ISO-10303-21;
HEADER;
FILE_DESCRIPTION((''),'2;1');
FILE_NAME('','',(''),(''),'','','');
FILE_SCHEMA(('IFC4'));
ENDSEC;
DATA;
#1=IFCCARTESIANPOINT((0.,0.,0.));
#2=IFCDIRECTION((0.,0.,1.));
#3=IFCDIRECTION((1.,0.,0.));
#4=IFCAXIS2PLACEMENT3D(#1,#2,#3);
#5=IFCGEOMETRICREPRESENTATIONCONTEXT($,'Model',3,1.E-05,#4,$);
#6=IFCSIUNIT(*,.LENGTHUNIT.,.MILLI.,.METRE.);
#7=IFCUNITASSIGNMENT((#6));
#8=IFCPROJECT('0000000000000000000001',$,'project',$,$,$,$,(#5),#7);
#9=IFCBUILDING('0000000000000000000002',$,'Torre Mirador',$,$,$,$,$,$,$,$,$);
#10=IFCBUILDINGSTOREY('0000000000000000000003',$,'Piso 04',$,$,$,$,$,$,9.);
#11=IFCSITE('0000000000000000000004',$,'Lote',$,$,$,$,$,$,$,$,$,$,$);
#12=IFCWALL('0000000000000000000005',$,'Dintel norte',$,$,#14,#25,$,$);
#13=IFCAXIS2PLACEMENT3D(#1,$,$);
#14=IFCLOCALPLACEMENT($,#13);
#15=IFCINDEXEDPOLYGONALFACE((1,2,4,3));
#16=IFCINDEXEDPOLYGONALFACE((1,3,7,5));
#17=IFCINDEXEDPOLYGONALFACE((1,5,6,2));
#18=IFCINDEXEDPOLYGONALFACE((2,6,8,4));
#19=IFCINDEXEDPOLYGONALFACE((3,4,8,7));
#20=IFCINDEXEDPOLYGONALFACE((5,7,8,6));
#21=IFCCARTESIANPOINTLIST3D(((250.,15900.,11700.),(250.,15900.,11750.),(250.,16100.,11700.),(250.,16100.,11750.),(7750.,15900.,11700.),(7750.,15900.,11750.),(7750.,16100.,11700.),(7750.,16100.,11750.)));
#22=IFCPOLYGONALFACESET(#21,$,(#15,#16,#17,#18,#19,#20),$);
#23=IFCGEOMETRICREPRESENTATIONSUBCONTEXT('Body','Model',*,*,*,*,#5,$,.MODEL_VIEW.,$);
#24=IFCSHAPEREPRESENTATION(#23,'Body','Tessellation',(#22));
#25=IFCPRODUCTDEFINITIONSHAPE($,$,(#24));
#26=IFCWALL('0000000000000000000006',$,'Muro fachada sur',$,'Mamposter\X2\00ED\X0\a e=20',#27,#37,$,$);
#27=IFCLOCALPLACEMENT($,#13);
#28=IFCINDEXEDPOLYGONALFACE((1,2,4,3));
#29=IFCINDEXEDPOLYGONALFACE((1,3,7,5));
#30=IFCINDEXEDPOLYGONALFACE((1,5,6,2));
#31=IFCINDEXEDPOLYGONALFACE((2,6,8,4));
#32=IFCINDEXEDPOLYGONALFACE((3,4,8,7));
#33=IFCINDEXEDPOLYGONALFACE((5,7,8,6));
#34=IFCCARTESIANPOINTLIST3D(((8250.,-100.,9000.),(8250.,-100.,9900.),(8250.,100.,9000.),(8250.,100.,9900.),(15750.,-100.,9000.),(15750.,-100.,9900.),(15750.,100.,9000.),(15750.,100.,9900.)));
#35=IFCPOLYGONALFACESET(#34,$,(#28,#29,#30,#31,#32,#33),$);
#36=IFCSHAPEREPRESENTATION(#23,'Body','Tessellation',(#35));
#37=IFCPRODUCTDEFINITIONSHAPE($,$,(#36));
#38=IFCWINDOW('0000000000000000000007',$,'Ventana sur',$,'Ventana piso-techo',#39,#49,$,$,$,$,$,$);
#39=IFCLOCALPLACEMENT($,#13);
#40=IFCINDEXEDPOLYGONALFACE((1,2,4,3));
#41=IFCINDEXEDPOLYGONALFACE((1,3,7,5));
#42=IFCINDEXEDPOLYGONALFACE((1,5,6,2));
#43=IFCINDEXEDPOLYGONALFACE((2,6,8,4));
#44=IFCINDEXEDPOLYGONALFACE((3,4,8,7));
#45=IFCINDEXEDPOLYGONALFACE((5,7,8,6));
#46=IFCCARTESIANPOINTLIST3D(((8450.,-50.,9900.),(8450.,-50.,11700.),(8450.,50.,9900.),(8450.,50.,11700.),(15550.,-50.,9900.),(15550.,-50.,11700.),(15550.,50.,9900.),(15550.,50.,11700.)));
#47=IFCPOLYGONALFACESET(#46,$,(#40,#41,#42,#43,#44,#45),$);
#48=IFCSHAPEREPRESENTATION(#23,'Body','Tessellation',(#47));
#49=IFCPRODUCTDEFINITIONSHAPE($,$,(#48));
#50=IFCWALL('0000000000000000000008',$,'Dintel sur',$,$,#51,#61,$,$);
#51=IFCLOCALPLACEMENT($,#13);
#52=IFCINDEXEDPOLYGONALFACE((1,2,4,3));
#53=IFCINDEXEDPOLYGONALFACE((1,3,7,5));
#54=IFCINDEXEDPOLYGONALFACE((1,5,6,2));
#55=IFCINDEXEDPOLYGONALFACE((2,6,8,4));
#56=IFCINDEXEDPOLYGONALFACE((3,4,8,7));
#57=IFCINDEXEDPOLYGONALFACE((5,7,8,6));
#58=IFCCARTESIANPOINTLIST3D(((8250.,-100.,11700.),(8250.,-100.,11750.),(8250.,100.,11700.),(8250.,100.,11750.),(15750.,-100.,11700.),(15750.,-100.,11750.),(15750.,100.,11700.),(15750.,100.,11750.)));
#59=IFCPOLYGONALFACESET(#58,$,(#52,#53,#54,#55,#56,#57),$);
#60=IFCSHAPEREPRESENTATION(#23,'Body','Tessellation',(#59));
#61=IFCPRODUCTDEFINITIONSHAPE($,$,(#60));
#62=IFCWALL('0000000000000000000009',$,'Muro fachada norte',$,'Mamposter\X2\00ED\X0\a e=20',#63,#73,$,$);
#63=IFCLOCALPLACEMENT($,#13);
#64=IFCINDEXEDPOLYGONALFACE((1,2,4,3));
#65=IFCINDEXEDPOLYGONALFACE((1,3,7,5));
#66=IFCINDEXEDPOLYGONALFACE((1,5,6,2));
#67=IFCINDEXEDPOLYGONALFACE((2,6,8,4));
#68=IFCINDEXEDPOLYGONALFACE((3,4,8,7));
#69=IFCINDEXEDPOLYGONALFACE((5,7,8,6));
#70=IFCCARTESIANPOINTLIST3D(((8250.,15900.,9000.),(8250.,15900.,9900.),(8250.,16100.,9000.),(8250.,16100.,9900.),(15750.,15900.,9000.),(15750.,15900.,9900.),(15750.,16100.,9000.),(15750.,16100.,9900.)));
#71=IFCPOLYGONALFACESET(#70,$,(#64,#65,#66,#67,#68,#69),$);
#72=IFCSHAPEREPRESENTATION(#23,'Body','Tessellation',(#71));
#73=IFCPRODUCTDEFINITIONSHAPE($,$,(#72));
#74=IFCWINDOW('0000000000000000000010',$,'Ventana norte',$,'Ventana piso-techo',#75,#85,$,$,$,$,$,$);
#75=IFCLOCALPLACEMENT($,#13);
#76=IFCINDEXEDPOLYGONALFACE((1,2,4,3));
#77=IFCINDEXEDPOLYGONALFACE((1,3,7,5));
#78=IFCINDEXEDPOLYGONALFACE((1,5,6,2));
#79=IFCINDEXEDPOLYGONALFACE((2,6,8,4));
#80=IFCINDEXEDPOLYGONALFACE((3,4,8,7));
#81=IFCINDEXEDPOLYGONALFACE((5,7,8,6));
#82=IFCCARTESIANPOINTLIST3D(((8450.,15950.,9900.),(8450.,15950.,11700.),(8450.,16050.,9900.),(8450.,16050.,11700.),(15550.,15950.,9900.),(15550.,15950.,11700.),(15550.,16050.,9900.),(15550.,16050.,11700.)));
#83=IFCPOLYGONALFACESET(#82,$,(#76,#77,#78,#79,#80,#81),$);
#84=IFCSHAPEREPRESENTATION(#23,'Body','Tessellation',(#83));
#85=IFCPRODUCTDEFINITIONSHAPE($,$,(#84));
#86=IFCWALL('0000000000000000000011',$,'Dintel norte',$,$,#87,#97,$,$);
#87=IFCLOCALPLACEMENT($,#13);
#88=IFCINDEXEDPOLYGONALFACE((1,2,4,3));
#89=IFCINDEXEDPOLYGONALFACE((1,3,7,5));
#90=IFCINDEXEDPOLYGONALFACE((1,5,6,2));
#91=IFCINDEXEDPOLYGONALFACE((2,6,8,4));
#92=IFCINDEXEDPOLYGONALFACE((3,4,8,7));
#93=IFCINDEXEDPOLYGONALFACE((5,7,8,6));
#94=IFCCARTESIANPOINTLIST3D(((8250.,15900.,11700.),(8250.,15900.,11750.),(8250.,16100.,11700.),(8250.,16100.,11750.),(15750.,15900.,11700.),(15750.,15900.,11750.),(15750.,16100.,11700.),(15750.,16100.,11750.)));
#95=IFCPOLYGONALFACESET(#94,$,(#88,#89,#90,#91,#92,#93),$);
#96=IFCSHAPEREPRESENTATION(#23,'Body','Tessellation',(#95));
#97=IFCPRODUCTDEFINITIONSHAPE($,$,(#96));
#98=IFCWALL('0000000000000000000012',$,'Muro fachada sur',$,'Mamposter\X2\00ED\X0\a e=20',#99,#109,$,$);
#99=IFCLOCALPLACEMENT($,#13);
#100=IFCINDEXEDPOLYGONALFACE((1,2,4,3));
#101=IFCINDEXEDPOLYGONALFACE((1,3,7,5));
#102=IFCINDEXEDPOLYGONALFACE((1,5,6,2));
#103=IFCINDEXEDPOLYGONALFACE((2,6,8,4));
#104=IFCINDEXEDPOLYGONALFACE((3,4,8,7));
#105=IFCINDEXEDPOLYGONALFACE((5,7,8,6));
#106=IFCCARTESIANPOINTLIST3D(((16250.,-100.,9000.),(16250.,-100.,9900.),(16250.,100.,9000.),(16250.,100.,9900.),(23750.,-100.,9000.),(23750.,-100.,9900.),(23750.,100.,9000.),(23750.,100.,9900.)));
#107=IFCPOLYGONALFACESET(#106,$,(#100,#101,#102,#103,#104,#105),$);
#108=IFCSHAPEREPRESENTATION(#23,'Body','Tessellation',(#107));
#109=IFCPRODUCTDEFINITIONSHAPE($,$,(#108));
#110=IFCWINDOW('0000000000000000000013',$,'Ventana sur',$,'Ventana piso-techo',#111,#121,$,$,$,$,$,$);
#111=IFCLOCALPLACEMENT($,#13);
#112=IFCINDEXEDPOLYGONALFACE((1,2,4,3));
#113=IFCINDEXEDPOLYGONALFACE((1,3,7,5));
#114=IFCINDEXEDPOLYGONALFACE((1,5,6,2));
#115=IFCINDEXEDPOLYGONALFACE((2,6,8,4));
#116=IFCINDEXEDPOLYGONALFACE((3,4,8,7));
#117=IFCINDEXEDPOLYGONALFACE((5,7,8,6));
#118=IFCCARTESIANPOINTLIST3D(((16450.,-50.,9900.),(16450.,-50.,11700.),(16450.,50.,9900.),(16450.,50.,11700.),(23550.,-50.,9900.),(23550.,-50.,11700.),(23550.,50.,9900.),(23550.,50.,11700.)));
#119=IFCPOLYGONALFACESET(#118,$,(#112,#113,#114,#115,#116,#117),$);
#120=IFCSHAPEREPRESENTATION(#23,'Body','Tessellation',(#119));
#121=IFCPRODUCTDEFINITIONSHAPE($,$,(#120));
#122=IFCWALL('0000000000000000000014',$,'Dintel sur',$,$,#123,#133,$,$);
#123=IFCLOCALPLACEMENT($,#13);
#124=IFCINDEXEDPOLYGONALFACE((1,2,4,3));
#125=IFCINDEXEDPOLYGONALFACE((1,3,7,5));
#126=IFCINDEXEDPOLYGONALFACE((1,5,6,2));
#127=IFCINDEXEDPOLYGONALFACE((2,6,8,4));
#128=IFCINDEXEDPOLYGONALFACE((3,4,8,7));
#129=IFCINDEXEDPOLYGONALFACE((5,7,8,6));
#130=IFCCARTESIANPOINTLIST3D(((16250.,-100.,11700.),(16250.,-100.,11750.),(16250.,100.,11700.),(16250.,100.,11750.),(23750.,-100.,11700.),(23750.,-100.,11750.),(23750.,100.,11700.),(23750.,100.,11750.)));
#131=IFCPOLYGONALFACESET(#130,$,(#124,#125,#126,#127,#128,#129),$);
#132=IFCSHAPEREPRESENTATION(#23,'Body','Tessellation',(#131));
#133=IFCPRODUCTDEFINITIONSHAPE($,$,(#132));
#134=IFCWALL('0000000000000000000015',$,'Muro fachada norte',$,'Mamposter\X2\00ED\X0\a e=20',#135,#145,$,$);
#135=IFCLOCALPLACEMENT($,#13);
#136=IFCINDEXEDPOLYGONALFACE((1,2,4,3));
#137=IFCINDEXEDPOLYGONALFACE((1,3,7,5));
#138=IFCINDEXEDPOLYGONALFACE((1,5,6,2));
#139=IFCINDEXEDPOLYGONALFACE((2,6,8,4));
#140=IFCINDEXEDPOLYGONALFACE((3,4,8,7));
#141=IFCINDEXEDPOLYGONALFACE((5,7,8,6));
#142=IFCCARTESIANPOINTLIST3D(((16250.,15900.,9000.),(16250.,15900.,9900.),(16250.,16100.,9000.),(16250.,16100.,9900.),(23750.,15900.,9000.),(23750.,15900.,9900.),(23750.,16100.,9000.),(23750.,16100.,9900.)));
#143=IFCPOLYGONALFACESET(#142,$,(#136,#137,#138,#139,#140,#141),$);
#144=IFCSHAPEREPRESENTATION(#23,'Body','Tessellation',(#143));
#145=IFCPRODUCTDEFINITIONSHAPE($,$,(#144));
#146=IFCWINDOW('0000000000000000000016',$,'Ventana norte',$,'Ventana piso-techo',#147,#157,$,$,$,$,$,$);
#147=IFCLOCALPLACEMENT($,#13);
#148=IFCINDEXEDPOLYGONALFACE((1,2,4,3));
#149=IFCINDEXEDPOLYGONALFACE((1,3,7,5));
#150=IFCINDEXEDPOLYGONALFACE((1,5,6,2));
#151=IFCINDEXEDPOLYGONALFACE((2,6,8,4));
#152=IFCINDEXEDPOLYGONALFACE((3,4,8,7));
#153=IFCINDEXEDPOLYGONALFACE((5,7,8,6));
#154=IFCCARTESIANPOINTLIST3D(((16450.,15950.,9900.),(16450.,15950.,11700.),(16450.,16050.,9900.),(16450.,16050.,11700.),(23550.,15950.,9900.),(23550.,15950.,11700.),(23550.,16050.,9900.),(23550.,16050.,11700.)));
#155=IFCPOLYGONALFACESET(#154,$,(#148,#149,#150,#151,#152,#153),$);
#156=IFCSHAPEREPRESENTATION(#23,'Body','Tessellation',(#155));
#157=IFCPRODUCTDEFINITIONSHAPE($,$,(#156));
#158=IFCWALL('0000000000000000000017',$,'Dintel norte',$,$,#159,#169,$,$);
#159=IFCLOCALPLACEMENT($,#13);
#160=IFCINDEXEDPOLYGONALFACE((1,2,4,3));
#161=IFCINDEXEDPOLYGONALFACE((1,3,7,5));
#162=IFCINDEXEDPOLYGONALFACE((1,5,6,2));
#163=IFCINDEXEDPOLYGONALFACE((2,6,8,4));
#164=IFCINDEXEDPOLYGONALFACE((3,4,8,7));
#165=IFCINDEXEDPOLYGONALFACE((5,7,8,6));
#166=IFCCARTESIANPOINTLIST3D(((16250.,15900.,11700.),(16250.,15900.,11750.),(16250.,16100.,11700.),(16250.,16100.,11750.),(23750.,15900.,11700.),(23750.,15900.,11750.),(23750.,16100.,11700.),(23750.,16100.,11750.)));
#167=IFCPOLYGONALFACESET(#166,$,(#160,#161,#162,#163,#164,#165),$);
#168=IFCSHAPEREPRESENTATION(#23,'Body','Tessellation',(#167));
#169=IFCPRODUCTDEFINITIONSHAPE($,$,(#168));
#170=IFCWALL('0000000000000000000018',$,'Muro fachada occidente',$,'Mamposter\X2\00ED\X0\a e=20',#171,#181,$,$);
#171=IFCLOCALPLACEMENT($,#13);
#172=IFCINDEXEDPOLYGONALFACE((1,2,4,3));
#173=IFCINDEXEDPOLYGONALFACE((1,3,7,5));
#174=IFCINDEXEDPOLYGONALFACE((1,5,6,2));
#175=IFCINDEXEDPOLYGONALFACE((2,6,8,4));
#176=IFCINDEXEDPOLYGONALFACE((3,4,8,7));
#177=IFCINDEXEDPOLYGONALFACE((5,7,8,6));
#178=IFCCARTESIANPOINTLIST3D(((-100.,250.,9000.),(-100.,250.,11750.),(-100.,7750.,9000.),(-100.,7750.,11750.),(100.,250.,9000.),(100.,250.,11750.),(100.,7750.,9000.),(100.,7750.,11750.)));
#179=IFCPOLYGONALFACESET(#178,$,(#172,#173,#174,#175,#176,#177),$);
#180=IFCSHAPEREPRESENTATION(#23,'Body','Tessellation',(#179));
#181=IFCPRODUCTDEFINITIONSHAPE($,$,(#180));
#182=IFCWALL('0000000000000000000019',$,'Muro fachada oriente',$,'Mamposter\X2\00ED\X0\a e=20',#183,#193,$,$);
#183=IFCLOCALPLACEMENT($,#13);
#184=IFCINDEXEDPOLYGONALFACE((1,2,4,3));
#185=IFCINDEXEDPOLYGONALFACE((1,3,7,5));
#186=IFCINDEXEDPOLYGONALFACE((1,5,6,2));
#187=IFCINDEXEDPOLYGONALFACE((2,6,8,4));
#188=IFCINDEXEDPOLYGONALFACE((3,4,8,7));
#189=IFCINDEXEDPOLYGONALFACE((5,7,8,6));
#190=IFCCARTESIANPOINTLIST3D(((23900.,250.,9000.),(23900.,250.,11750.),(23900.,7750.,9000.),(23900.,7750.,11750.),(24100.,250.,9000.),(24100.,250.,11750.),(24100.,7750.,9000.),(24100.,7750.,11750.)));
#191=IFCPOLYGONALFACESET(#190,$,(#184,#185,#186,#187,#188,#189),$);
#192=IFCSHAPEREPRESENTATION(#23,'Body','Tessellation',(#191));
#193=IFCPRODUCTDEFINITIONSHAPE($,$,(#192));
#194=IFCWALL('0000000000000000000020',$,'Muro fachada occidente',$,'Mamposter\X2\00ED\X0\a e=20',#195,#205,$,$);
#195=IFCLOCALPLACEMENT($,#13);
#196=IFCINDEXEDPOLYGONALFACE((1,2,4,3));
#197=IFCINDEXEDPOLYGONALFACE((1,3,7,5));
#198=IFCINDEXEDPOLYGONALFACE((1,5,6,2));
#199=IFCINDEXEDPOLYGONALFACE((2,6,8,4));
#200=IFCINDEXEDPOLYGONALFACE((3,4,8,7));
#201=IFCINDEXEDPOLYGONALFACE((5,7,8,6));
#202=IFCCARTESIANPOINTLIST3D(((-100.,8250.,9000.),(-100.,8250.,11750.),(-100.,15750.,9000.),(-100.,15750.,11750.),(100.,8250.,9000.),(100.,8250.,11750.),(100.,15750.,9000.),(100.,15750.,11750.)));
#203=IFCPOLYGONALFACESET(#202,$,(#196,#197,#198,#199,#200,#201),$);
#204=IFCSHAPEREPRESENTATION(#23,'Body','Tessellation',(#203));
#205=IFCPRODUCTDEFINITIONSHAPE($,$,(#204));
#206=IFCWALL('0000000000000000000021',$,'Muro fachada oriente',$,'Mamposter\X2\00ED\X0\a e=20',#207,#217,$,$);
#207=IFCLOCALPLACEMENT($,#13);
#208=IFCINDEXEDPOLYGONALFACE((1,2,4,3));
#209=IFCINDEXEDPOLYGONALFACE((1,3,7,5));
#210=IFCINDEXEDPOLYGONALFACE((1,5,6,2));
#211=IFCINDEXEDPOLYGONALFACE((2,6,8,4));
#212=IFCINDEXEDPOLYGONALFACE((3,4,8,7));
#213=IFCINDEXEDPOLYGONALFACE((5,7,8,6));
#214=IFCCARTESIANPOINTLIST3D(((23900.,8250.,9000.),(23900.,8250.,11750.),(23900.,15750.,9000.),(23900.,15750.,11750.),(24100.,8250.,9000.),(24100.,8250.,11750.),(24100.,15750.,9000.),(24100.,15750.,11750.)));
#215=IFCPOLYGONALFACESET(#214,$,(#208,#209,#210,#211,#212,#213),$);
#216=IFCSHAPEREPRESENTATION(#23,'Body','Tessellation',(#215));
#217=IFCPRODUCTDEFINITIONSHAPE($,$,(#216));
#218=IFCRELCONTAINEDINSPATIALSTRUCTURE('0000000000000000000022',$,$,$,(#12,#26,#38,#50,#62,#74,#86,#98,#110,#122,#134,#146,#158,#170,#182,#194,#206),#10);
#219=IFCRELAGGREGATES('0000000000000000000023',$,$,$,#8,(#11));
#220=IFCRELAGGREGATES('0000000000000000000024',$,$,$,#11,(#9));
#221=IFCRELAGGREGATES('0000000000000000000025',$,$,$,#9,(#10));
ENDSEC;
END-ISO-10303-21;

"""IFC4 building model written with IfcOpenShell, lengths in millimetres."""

from ifc_helpers import new_model, si_unit, frame, origin_with_axes, place, context, subcontext, project, spatial, indexed_curve, outline, extrude, element, save


model = new_model("IFC4")

# Units and contexts
model_context = context("Model", 3, precision=1e-05, world=origin_with_axes())
body_context = subcontext(model_context, "Body", "Model", "MODEL_VIEW")
ifc_project = project(units=[si_unit("LENGTHUNIT", "METRE", prefix="MILLI")], contexts=[model_context])

# Site, building, storey
site = spatial("IfcSite", under=ifc_project, Name="Lote")
building = spatial("IfcBuilding", under=site, Name="Torre Mirador")
storey = spatial("IfcBuildingStorey", under=building, Name="Piso 04", Elevation=9.0)

# Walls
wall_1_placement = place(None, frame((250.0, 15900.0, 11700.0), z_axis=(0.0, 0.0, 1.0), x_axis=(1.0, 0.0, 0.0)))
element("IfcWall", 1, at=wall_1_placement, inside=storey, Name="Dintel norte", context=body_context, shape_type="SweptSolid", body=[
    extrude(outline(indexed_curve([(0.0, 0.0), (0.0, 200.0), (7500.0, 200.0), (7500.0, 0.0), (0.0, 0.0)], self_intersect=False)), origin_with_axes(), (0.0, 0.0, 1.0), 50.0),
])
wall_2_placement = place(None, frame((8250.0, -100.0, 9000.0), z_axis=(0.0, 0.0, 1.0), x_axis=(1.0, 0.0, 0.0)))
element("IfcWall", 2, at=wall_2_placement, inside=storey, Name="Muro fachada sur", ObjectType="Mampostería e=20", context=body_context, shape_type="SweptSolid", body=[
    extrude(outline(indexed_curve([(0.0, 0.0), (0.0, 200.0), (7500.0, 200.0), (7500.0, 0.0), (0.0, 0.0)], self_intersect=False)), origin_with_axes(), (0.0, 0.0, 1.0), 900.0),
])

# Window
window_1_placement = place(None, frame((8450.0, -50.0, 9900.0), z_axis=(0.0, 0.0, 1.0), x_axis=(1.0, 0.0, 0.0)))
element("IfcWindow", 3, at=window_1_placement, inside=storey, Name="Ventana sur", ObjectType="Ventana piso-techo", context=body_context, shape_type="SweptSolid", body=[
    extrude(outline(indexed_curve([(0.0, 0.0), (0.0, 100.0), (7100.0, 100.0), (7100.0, 0.0), (0.0, 0.0)], self_intersect=False)), origin_with_axes(), (0.0, 0.0, 1.0), 1800.0),
])

# Walls
wall_3_placement = place(None, frame((8250.0, -100.0, 11700.0), z_axis=(0.0, 0.0, 1.0), x_axis=(1.0, 0.0, 0.0)))
element("IfcWall", 4, at=wall_3_placement, inside=storey, Name="Dintel sur", context=body_context, shape_type="SweptSolid", body=[
    extrude(outline(indexed_curve([(0.0, 0.0), (0.0, 200.0), (7500.0, 200.0), (7500.0, 0.0), (0.0, 0.0)], self_intersect=False)), origin_with_axes(), (0.0, 0.0, 1.0), 50.0),
])
wall_4_placement = place(None, frame((8250.0, 15900.0, 9000.0), z_axis=(0.0, 0.0, 1.0), x_axis=(1.0, 0.0, 0.0)))
element("IfcWall", 5, at=wall_4_placement, inside=storey, Name="Muro fachada norte", ObjectType="Mampostería e=20", context=body_context, shape_type="SweptSolid", body=[
    extrude(outline(indexed_curve([(0.0, 0.0), (0.0, 200.0), (7500.0, 200.0), (7500.0, 0.0), (0.0, 0.0)], self_intersect=False)), origin_with_axes(), (0.0, 0.0, 1.0), 900.0),
])

# Window
window_2_placement = place(None, frame((8450.0, 15950.0, 9900.0), z_axis=(0.0, 0.0, 1.0), x_axis=(1.0, 0.0, 0.0)))
element("IfcWindow", 6, at=window_2_placement, inside=storey, Name="Ventana norte", ObjectType="Ventana piso-techo", context=body_context, shape_type="SweptSolid", body=[
    extrude(outline(indexed_curve([(0.0, 0.0), (0.0, 100.0), (7100.0, 100.0), (7100.0, 0.0), (0.0, 0.0)], self_intersect=False)), origin_with_axes(), (0.0, 0.0, 1.0), 1800.0),
])

# Walls
wall_5_placement = place(None, frame((8250.0, 15900.0, 11700.0), z_axis=(0.0, 0.0, 1.0), x_axis=(1.0, 0.0, 0.0)))
element("IfcWall", 7, at=wall_5_placement, inside=storey, Name="Dintel norte", context=body_context, shape_type="SweptSolid", body=[
    extrude(outline(indexed_curve([(0.0, 0.0), (0.0, 200.0), (7500.0, 200.0), (7500.0, 0.0), (0.0, 0.0)], self_intersect=False)), origin_with_axes(), (0.0, 0.0, 1.0), 50.0),
])
wall_6_placement = place(None, frame((16250.0, -100.0, 9000.0), z_axis=(0.0, 0.0, 1.0), x_axis=(1.0, 0.0, 0.0)))
element("IfcWall", 8, at=wall_6_placement, inside=storey, Name="Muro fachada sur", ObjectType="Mampostería e=20", context=body_context, shape_type="SweptSolid", body=[
    extrude(outline(indexed_curve([(0.0, 0.0), (0.0, 200.0), (7500.0, 200.0), (7500.0, 0.0), (0.0, 0.0)], self_intersect=False)), origin_with_axes(), (0.0, 0.0, 1.0), 900.0),
])

# Window
window_3_placement = place(None, frame((16450.0, -50.0, 9900.0), z_axis=(0.0, 0.0, 1.0), x_axis=(1.0, 0.0, 0.0)))
element("IfcWindow", 9, at=window_3_placement, inside=storey, Name="Ventana sur", ObjectType="Ventana piso-techo", context=body_context, shape_type="SweptSolid", body=[
    extrude(outline(indexed_curve([(0.0, 0.0), (0.0, 100.0), (7100.0, 100.0), (7100.0, 0.0), (0.0, 0.0)], self_intersect=False)), origin_with_axes(), (0.0, 0.0, 1.0), 1800.0),
])

# Walls
wall_7_placement = place(None, frame((16250.0, -100.0, 11700.0), z_axis=(0.0, 0.0, 1.0), x_axis=(1.0, 0.0, 0.0)))
element("IfcWall", 10, at=wall_7_placement, inside=storey, Name="Dintel sur", context=body_context, shape_type="SweptSolid", body=[
    extrude(outline(indexed_curve([(0.0, 0.0), (0.0, 200.0), (7500.0, 200.0), (7500.0, 0.0), (0.0, 0.0)], self_intersect=False)), origin_with_axes(), (0.0, 0.0, 1.0), 50.0),
])
wall_8_placement = place(None, frame((16250.0, 15900.0, 9000.0), z_axis=(0.0, 0.0, 1.0), x_axis=(1.0, 0.0, 0.0)))
element("IfcWall", 11, at=wall_8_placement, inside=storey, Name="Muro fachada norte", ObjectType="Mampostería e=20", context=body_context, shape_type="SweptSolid", body=[
    extrude(outline(indexed_curve([(0.0, 0.0), (0.0, 200.0), (7500.0, 200.0), (7500.0, 0.0), (0.0, 0.0)], self_intersect=False)), origin_with_axes(), (0.0, 0.0, 1.0), 900.0),
])

# Window
window_4_placement = place(None, frame((16450.0, 15950.0, 9900.0), z_axis=(0.0, 0.0, 1.0), x_axis=(1.0, 0.0, 0.0)))
element("IfcWindow", 12, at=window_4_placement, inside=storey, Name="Ventana norte", ObjectType="Ventana piso-techo", context=body_context, shape_type="SweptSolid", body=[
    extrude(outline(indexed_curve([(0.0, 0.0), (0.0, 100.0), (7100.0, 100.0), (7100.0, 0.0), (0.0, 0.0)], self_intersect=False)), origin_with_axes(), (0.0, 0.0, 1.0), 1800.0),
])

# Walls
wall_9_placement = place(None, frame((16250.0, 15900.0, 11700.0), z_axis=(0.0, 0.0, 1.0), x_axis=(1.0, 0.0, 0.0)))
element("IfcWall", 13, at=wall_9_placement, inside=storey, Name="Dintel norte", context=body_context, shape_type="SweptSolid", body=[
    extrude(outline(indexed_curve([(0.0, 0.0), (0.0, 200.0), (7500.0, 200.0), (7500.0, 0.0), (0.0, 0.0)], self_intersect=False)), origin_with_axes(), (0.0, 0.0, 1.0), 50.0),
])
for number, where, z_axis, x_axis, name in (
    (14, (-100.0, 250.0, 9000.0), (0.0, 0.0, 1.0), (1.0, 0.0, 0.0), "Muro fachada occidente"),
    (15, (23900.0, 250.0, 9000.0), (0.0, 0.0, 1.0), (1.0, 0.0, 0.0), "Muro fachada oriente"),
    (16, (-100.0, 8250.0, 9000.0), (0.0, 0.0, 1.0), (1.0, 0.0, 0.0), "Muro fachada occidente"),
    (17, (23900.0, 8250.0, 9000.0), (0.0, 0.0, 1.0), (1.0, 0.0, 0.0), "Muro fachada oriente"),
):
    element("IfcWall", number, at=place(None, frame(where, z_axis=z_axis, x_axis=x_axis)), inside=storey, Name=name, ObjectType="Mampostería e=20", context=body_context, shape_type="SweptSolid", body=[
        extrude(outline(indexed_curve([(0.0, 0.0), (0.0, 7500.0), (200.0, 7500.0), (200.0, 0.0), (0.0, 0.0)], self_intersect=False)), origin_with_axes(), (0.0, 0.0, 1.0), 2750.0),
    ])

save(model, "model.ifc")
